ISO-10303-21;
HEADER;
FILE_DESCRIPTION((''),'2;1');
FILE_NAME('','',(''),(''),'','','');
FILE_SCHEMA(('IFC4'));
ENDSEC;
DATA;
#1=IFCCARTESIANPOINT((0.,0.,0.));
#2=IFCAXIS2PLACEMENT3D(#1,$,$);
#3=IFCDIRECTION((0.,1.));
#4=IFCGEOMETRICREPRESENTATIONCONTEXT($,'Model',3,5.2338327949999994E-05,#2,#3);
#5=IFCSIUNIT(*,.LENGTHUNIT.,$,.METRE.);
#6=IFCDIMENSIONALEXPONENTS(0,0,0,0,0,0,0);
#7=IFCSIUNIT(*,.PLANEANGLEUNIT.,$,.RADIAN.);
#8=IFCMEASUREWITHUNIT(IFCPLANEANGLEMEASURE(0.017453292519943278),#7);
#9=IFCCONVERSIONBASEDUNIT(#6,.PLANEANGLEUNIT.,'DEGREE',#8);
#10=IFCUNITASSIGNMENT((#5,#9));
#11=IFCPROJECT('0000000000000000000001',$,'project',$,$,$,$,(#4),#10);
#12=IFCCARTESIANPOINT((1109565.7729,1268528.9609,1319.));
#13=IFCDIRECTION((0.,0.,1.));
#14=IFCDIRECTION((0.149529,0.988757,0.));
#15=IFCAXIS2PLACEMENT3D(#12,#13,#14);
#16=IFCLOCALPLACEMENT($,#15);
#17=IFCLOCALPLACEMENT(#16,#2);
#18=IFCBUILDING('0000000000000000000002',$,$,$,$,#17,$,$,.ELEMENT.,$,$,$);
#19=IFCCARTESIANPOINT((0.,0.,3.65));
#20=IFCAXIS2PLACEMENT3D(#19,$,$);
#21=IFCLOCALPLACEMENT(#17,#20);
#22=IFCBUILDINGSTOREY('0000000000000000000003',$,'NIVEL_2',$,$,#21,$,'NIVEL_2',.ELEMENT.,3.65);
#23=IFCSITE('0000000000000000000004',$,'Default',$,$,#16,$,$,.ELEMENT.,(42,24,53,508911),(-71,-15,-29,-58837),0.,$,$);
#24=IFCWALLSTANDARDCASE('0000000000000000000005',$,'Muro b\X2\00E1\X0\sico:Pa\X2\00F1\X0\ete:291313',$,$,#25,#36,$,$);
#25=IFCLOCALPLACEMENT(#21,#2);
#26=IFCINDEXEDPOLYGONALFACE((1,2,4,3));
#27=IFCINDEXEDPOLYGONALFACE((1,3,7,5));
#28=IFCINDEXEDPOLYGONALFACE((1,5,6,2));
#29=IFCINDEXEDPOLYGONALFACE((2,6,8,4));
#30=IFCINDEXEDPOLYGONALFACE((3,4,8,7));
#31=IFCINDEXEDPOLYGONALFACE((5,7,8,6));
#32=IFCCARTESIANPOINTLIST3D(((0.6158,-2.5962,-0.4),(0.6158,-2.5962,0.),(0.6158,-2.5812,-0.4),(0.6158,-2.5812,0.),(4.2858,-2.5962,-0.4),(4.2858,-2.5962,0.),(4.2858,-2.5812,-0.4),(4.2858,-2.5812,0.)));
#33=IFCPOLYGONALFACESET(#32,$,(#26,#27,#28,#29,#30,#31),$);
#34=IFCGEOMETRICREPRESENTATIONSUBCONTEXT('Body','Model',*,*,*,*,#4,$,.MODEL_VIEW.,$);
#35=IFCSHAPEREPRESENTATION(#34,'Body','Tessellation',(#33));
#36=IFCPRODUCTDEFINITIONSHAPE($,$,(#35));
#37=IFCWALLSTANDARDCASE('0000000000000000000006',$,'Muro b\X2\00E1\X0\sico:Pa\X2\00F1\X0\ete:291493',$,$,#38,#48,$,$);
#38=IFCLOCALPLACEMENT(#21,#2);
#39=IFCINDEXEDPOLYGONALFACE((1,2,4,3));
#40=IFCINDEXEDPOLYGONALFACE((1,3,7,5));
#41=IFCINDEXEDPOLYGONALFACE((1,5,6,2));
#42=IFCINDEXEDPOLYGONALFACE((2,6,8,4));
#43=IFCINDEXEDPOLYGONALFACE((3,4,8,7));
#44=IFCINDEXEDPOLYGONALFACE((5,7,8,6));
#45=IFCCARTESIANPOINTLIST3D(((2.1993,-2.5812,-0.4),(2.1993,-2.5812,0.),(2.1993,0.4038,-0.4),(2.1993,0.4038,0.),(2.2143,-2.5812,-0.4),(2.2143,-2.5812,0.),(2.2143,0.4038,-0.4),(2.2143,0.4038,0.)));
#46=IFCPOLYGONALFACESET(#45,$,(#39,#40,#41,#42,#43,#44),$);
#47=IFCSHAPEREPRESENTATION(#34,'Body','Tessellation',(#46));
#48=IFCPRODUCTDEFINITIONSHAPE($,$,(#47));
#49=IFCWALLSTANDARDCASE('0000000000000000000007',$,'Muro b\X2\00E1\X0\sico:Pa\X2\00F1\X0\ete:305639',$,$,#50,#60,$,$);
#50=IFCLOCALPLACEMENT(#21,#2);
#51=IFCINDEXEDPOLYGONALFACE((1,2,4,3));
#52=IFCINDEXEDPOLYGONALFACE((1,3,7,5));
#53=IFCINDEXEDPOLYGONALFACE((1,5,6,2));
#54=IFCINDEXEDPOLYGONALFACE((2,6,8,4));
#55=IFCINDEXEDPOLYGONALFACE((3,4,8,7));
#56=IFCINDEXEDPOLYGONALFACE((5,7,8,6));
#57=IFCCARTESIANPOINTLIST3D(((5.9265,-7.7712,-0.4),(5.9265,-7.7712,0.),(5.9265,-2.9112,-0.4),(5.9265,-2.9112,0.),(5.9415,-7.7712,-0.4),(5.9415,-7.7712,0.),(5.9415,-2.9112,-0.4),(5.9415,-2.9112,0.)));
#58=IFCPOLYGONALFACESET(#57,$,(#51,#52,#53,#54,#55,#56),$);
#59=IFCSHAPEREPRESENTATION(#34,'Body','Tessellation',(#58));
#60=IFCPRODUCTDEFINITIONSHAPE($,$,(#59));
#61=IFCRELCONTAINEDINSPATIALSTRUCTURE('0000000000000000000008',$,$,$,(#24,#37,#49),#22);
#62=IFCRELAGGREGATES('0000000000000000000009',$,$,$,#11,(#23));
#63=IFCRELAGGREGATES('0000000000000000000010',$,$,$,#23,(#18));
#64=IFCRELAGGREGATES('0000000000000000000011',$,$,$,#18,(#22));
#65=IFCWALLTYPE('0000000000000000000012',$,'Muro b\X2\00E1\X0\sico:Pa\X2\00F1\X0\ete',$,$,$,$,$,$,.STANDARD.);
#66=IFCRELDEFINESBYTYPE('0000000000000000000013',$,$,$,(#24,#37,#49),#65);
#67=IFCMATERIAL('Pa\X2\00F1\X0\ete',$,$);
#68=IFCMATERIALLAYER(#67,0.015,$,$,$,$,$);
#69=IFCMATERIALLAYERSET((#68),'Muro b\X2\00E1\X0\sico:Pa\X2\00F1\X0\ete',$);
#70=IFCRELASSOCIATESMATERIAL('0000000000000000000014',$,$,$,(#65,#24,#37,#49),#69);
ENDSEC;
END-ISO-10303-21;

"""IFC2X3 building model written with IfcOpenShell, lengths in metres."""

from ifc_helpers import new_model, entity, si_unit, converted_unit, direction, frame, frame_2d, origin, place, context, subcontext, project, spatial, rectangle, extrude, material, layer, layer_set, layer_usage, type_object, element, save


model = new_model("IFC2X3")

# Units and contexts
model_context = context("Model", 3, precision=5.2338327949999994e-05, world=origin(), true_north=direction((0.0, 1.0)))
body_context = subcontext(model_context, "Body", "Model", "MODEL_VIEW")
ifc_project = project(units=[si_unit("LENGTHUNIT", "METRE"), converted_unit("PLANEANGLEUNIT", "DEGREE", entity("IfcPlaneAngleMeasure", 0.017453292519943278), si_unit("PLANEANGLEUNIT", "RADIAN"), dimensions=[0, 0, 0, 0, 0, 0, 0])], contexts=[model_context])

# Site, building, storey
site_placement = place(None, frame((1109565.7729, 1268528.9609, 1319.0), z_axis=(0.0, 0.0, 1.0), x_axis=(0.149529, 0.988757, 0.0)))
site = spatial("IfcSite", under=ifc_project, at=site_placement, Name="Default", CompositionType="ELEMENT", RefLatitude=(42, 24, 53, 508911), RefLongitude=(-71, -15, -29, -58837), RefElevation=0.0)
building_placement = place(site_placement, origin())
building = spatial("IfcBuilding", under=site, at=building_placement, CompositionType="ELEMENT")
storey_placement = place(building_placement, frame((0.0, 0.0, 3.65)))
storey = spatial("IfcBuildingStorey", under=building, at=storey_placement, Name="NIVEL_2", LongName="NIVEL_2", CompositionType="ELEMENT", Elevation=3.65)

# Shared definitions
ifc_material_1 = material(Name="Pañete")
ifc_layer_1 = layer(ifc_material_1, 0.015)
ifc_layer_set_1 = layer_set([ifc_layer_1], Name="Muro básico:Pañete")
wall_type_1 = type_object("IfcWallType", Name="Muro básico:Pañete", PredefinedType="STANDARD", material=ifc_layer_set_1)

# Walls
ifc_layer_usage_1 = layer_usage(ifc_layer_set_1, "AXIS2", "POSITIVE", -0.0075)
wall_1_placement = place(storey_placement, frame((4.2858, -2.5887, -0.4), z_axis=(0.0, 0.0, 1.0), x_axis=(-1.0, 0.0, 0.0)))
element("IfcWallStandardCase", 1, at=wall_1_placement, inside=storey, type_object=wall_type_1, material=ifc_layer_usage_1, Name="Muro básico:Pañete:291313", context=body_context, shape_type="SweptSolid", body=[
    extrude(rectangle(XDim=3.67, YDim=0.015, at=frame_2d((1.835, 0.0), x_axis=(-1.0, 0.0))), origin(), (0.0, 0.0, 1.0), 0.4),
])
ifc_layer_usage_2 = layer_usage(ifc_layer_set_1, "AXIS2", "POSITIVE", -0.0075)
wall_2_placement = place(storey_placement, frame((2.2068, -2.5812, -0.4), z_axis=(0.0, 0.0, 1.0), x_axis=(0.0, 1.0, 0.0)))
element("IfcWallStandardCase", 2, at=wall_2_placement, inside=storey, type_object=wall_type_1, material=ifc_layer_usage_2, Name="Muro básico:Pañete:291493", context=body_context, shape_type="SweptSolid", body=[
    extrude(rectangle(XDim=2.985, YDim=0.015, at=frame_2d((1.4925, 0.0), x_axis=(-1.0, 0.0))), origin(), (0.0, 0.0, 1.0), 0.4),
])
ifc_layer_usage_3 = layer_usage(ifc_layer_set_1, "AXIS2", "NEGATIVE", 0.0075)
wall_3_placement = place(storey_placement, frame((5.934, -2.9112, -0.4), z_axis=(0.0, 0.0, 1.0), x_axis=(0.0, -1.0, 0.0)))
element("IfcWallStandardCase", 3, at=wall_3_placement, inside=storey, type_object=wall_type_1, material=ifc_layer_usage_3, Name="Muro básico:Pañete:305639", context=body_context, shape_type="SweptSolid", body=[
    extrude(rectangle(XDim=4.86, YDim=0.015, at=frame_2d((2.43, 0.0), x_axis=(-1.0, 0.0))), origin(), (0.0, 0.0, 1.0), 0.4),
])

save(model, "model.ifc")
